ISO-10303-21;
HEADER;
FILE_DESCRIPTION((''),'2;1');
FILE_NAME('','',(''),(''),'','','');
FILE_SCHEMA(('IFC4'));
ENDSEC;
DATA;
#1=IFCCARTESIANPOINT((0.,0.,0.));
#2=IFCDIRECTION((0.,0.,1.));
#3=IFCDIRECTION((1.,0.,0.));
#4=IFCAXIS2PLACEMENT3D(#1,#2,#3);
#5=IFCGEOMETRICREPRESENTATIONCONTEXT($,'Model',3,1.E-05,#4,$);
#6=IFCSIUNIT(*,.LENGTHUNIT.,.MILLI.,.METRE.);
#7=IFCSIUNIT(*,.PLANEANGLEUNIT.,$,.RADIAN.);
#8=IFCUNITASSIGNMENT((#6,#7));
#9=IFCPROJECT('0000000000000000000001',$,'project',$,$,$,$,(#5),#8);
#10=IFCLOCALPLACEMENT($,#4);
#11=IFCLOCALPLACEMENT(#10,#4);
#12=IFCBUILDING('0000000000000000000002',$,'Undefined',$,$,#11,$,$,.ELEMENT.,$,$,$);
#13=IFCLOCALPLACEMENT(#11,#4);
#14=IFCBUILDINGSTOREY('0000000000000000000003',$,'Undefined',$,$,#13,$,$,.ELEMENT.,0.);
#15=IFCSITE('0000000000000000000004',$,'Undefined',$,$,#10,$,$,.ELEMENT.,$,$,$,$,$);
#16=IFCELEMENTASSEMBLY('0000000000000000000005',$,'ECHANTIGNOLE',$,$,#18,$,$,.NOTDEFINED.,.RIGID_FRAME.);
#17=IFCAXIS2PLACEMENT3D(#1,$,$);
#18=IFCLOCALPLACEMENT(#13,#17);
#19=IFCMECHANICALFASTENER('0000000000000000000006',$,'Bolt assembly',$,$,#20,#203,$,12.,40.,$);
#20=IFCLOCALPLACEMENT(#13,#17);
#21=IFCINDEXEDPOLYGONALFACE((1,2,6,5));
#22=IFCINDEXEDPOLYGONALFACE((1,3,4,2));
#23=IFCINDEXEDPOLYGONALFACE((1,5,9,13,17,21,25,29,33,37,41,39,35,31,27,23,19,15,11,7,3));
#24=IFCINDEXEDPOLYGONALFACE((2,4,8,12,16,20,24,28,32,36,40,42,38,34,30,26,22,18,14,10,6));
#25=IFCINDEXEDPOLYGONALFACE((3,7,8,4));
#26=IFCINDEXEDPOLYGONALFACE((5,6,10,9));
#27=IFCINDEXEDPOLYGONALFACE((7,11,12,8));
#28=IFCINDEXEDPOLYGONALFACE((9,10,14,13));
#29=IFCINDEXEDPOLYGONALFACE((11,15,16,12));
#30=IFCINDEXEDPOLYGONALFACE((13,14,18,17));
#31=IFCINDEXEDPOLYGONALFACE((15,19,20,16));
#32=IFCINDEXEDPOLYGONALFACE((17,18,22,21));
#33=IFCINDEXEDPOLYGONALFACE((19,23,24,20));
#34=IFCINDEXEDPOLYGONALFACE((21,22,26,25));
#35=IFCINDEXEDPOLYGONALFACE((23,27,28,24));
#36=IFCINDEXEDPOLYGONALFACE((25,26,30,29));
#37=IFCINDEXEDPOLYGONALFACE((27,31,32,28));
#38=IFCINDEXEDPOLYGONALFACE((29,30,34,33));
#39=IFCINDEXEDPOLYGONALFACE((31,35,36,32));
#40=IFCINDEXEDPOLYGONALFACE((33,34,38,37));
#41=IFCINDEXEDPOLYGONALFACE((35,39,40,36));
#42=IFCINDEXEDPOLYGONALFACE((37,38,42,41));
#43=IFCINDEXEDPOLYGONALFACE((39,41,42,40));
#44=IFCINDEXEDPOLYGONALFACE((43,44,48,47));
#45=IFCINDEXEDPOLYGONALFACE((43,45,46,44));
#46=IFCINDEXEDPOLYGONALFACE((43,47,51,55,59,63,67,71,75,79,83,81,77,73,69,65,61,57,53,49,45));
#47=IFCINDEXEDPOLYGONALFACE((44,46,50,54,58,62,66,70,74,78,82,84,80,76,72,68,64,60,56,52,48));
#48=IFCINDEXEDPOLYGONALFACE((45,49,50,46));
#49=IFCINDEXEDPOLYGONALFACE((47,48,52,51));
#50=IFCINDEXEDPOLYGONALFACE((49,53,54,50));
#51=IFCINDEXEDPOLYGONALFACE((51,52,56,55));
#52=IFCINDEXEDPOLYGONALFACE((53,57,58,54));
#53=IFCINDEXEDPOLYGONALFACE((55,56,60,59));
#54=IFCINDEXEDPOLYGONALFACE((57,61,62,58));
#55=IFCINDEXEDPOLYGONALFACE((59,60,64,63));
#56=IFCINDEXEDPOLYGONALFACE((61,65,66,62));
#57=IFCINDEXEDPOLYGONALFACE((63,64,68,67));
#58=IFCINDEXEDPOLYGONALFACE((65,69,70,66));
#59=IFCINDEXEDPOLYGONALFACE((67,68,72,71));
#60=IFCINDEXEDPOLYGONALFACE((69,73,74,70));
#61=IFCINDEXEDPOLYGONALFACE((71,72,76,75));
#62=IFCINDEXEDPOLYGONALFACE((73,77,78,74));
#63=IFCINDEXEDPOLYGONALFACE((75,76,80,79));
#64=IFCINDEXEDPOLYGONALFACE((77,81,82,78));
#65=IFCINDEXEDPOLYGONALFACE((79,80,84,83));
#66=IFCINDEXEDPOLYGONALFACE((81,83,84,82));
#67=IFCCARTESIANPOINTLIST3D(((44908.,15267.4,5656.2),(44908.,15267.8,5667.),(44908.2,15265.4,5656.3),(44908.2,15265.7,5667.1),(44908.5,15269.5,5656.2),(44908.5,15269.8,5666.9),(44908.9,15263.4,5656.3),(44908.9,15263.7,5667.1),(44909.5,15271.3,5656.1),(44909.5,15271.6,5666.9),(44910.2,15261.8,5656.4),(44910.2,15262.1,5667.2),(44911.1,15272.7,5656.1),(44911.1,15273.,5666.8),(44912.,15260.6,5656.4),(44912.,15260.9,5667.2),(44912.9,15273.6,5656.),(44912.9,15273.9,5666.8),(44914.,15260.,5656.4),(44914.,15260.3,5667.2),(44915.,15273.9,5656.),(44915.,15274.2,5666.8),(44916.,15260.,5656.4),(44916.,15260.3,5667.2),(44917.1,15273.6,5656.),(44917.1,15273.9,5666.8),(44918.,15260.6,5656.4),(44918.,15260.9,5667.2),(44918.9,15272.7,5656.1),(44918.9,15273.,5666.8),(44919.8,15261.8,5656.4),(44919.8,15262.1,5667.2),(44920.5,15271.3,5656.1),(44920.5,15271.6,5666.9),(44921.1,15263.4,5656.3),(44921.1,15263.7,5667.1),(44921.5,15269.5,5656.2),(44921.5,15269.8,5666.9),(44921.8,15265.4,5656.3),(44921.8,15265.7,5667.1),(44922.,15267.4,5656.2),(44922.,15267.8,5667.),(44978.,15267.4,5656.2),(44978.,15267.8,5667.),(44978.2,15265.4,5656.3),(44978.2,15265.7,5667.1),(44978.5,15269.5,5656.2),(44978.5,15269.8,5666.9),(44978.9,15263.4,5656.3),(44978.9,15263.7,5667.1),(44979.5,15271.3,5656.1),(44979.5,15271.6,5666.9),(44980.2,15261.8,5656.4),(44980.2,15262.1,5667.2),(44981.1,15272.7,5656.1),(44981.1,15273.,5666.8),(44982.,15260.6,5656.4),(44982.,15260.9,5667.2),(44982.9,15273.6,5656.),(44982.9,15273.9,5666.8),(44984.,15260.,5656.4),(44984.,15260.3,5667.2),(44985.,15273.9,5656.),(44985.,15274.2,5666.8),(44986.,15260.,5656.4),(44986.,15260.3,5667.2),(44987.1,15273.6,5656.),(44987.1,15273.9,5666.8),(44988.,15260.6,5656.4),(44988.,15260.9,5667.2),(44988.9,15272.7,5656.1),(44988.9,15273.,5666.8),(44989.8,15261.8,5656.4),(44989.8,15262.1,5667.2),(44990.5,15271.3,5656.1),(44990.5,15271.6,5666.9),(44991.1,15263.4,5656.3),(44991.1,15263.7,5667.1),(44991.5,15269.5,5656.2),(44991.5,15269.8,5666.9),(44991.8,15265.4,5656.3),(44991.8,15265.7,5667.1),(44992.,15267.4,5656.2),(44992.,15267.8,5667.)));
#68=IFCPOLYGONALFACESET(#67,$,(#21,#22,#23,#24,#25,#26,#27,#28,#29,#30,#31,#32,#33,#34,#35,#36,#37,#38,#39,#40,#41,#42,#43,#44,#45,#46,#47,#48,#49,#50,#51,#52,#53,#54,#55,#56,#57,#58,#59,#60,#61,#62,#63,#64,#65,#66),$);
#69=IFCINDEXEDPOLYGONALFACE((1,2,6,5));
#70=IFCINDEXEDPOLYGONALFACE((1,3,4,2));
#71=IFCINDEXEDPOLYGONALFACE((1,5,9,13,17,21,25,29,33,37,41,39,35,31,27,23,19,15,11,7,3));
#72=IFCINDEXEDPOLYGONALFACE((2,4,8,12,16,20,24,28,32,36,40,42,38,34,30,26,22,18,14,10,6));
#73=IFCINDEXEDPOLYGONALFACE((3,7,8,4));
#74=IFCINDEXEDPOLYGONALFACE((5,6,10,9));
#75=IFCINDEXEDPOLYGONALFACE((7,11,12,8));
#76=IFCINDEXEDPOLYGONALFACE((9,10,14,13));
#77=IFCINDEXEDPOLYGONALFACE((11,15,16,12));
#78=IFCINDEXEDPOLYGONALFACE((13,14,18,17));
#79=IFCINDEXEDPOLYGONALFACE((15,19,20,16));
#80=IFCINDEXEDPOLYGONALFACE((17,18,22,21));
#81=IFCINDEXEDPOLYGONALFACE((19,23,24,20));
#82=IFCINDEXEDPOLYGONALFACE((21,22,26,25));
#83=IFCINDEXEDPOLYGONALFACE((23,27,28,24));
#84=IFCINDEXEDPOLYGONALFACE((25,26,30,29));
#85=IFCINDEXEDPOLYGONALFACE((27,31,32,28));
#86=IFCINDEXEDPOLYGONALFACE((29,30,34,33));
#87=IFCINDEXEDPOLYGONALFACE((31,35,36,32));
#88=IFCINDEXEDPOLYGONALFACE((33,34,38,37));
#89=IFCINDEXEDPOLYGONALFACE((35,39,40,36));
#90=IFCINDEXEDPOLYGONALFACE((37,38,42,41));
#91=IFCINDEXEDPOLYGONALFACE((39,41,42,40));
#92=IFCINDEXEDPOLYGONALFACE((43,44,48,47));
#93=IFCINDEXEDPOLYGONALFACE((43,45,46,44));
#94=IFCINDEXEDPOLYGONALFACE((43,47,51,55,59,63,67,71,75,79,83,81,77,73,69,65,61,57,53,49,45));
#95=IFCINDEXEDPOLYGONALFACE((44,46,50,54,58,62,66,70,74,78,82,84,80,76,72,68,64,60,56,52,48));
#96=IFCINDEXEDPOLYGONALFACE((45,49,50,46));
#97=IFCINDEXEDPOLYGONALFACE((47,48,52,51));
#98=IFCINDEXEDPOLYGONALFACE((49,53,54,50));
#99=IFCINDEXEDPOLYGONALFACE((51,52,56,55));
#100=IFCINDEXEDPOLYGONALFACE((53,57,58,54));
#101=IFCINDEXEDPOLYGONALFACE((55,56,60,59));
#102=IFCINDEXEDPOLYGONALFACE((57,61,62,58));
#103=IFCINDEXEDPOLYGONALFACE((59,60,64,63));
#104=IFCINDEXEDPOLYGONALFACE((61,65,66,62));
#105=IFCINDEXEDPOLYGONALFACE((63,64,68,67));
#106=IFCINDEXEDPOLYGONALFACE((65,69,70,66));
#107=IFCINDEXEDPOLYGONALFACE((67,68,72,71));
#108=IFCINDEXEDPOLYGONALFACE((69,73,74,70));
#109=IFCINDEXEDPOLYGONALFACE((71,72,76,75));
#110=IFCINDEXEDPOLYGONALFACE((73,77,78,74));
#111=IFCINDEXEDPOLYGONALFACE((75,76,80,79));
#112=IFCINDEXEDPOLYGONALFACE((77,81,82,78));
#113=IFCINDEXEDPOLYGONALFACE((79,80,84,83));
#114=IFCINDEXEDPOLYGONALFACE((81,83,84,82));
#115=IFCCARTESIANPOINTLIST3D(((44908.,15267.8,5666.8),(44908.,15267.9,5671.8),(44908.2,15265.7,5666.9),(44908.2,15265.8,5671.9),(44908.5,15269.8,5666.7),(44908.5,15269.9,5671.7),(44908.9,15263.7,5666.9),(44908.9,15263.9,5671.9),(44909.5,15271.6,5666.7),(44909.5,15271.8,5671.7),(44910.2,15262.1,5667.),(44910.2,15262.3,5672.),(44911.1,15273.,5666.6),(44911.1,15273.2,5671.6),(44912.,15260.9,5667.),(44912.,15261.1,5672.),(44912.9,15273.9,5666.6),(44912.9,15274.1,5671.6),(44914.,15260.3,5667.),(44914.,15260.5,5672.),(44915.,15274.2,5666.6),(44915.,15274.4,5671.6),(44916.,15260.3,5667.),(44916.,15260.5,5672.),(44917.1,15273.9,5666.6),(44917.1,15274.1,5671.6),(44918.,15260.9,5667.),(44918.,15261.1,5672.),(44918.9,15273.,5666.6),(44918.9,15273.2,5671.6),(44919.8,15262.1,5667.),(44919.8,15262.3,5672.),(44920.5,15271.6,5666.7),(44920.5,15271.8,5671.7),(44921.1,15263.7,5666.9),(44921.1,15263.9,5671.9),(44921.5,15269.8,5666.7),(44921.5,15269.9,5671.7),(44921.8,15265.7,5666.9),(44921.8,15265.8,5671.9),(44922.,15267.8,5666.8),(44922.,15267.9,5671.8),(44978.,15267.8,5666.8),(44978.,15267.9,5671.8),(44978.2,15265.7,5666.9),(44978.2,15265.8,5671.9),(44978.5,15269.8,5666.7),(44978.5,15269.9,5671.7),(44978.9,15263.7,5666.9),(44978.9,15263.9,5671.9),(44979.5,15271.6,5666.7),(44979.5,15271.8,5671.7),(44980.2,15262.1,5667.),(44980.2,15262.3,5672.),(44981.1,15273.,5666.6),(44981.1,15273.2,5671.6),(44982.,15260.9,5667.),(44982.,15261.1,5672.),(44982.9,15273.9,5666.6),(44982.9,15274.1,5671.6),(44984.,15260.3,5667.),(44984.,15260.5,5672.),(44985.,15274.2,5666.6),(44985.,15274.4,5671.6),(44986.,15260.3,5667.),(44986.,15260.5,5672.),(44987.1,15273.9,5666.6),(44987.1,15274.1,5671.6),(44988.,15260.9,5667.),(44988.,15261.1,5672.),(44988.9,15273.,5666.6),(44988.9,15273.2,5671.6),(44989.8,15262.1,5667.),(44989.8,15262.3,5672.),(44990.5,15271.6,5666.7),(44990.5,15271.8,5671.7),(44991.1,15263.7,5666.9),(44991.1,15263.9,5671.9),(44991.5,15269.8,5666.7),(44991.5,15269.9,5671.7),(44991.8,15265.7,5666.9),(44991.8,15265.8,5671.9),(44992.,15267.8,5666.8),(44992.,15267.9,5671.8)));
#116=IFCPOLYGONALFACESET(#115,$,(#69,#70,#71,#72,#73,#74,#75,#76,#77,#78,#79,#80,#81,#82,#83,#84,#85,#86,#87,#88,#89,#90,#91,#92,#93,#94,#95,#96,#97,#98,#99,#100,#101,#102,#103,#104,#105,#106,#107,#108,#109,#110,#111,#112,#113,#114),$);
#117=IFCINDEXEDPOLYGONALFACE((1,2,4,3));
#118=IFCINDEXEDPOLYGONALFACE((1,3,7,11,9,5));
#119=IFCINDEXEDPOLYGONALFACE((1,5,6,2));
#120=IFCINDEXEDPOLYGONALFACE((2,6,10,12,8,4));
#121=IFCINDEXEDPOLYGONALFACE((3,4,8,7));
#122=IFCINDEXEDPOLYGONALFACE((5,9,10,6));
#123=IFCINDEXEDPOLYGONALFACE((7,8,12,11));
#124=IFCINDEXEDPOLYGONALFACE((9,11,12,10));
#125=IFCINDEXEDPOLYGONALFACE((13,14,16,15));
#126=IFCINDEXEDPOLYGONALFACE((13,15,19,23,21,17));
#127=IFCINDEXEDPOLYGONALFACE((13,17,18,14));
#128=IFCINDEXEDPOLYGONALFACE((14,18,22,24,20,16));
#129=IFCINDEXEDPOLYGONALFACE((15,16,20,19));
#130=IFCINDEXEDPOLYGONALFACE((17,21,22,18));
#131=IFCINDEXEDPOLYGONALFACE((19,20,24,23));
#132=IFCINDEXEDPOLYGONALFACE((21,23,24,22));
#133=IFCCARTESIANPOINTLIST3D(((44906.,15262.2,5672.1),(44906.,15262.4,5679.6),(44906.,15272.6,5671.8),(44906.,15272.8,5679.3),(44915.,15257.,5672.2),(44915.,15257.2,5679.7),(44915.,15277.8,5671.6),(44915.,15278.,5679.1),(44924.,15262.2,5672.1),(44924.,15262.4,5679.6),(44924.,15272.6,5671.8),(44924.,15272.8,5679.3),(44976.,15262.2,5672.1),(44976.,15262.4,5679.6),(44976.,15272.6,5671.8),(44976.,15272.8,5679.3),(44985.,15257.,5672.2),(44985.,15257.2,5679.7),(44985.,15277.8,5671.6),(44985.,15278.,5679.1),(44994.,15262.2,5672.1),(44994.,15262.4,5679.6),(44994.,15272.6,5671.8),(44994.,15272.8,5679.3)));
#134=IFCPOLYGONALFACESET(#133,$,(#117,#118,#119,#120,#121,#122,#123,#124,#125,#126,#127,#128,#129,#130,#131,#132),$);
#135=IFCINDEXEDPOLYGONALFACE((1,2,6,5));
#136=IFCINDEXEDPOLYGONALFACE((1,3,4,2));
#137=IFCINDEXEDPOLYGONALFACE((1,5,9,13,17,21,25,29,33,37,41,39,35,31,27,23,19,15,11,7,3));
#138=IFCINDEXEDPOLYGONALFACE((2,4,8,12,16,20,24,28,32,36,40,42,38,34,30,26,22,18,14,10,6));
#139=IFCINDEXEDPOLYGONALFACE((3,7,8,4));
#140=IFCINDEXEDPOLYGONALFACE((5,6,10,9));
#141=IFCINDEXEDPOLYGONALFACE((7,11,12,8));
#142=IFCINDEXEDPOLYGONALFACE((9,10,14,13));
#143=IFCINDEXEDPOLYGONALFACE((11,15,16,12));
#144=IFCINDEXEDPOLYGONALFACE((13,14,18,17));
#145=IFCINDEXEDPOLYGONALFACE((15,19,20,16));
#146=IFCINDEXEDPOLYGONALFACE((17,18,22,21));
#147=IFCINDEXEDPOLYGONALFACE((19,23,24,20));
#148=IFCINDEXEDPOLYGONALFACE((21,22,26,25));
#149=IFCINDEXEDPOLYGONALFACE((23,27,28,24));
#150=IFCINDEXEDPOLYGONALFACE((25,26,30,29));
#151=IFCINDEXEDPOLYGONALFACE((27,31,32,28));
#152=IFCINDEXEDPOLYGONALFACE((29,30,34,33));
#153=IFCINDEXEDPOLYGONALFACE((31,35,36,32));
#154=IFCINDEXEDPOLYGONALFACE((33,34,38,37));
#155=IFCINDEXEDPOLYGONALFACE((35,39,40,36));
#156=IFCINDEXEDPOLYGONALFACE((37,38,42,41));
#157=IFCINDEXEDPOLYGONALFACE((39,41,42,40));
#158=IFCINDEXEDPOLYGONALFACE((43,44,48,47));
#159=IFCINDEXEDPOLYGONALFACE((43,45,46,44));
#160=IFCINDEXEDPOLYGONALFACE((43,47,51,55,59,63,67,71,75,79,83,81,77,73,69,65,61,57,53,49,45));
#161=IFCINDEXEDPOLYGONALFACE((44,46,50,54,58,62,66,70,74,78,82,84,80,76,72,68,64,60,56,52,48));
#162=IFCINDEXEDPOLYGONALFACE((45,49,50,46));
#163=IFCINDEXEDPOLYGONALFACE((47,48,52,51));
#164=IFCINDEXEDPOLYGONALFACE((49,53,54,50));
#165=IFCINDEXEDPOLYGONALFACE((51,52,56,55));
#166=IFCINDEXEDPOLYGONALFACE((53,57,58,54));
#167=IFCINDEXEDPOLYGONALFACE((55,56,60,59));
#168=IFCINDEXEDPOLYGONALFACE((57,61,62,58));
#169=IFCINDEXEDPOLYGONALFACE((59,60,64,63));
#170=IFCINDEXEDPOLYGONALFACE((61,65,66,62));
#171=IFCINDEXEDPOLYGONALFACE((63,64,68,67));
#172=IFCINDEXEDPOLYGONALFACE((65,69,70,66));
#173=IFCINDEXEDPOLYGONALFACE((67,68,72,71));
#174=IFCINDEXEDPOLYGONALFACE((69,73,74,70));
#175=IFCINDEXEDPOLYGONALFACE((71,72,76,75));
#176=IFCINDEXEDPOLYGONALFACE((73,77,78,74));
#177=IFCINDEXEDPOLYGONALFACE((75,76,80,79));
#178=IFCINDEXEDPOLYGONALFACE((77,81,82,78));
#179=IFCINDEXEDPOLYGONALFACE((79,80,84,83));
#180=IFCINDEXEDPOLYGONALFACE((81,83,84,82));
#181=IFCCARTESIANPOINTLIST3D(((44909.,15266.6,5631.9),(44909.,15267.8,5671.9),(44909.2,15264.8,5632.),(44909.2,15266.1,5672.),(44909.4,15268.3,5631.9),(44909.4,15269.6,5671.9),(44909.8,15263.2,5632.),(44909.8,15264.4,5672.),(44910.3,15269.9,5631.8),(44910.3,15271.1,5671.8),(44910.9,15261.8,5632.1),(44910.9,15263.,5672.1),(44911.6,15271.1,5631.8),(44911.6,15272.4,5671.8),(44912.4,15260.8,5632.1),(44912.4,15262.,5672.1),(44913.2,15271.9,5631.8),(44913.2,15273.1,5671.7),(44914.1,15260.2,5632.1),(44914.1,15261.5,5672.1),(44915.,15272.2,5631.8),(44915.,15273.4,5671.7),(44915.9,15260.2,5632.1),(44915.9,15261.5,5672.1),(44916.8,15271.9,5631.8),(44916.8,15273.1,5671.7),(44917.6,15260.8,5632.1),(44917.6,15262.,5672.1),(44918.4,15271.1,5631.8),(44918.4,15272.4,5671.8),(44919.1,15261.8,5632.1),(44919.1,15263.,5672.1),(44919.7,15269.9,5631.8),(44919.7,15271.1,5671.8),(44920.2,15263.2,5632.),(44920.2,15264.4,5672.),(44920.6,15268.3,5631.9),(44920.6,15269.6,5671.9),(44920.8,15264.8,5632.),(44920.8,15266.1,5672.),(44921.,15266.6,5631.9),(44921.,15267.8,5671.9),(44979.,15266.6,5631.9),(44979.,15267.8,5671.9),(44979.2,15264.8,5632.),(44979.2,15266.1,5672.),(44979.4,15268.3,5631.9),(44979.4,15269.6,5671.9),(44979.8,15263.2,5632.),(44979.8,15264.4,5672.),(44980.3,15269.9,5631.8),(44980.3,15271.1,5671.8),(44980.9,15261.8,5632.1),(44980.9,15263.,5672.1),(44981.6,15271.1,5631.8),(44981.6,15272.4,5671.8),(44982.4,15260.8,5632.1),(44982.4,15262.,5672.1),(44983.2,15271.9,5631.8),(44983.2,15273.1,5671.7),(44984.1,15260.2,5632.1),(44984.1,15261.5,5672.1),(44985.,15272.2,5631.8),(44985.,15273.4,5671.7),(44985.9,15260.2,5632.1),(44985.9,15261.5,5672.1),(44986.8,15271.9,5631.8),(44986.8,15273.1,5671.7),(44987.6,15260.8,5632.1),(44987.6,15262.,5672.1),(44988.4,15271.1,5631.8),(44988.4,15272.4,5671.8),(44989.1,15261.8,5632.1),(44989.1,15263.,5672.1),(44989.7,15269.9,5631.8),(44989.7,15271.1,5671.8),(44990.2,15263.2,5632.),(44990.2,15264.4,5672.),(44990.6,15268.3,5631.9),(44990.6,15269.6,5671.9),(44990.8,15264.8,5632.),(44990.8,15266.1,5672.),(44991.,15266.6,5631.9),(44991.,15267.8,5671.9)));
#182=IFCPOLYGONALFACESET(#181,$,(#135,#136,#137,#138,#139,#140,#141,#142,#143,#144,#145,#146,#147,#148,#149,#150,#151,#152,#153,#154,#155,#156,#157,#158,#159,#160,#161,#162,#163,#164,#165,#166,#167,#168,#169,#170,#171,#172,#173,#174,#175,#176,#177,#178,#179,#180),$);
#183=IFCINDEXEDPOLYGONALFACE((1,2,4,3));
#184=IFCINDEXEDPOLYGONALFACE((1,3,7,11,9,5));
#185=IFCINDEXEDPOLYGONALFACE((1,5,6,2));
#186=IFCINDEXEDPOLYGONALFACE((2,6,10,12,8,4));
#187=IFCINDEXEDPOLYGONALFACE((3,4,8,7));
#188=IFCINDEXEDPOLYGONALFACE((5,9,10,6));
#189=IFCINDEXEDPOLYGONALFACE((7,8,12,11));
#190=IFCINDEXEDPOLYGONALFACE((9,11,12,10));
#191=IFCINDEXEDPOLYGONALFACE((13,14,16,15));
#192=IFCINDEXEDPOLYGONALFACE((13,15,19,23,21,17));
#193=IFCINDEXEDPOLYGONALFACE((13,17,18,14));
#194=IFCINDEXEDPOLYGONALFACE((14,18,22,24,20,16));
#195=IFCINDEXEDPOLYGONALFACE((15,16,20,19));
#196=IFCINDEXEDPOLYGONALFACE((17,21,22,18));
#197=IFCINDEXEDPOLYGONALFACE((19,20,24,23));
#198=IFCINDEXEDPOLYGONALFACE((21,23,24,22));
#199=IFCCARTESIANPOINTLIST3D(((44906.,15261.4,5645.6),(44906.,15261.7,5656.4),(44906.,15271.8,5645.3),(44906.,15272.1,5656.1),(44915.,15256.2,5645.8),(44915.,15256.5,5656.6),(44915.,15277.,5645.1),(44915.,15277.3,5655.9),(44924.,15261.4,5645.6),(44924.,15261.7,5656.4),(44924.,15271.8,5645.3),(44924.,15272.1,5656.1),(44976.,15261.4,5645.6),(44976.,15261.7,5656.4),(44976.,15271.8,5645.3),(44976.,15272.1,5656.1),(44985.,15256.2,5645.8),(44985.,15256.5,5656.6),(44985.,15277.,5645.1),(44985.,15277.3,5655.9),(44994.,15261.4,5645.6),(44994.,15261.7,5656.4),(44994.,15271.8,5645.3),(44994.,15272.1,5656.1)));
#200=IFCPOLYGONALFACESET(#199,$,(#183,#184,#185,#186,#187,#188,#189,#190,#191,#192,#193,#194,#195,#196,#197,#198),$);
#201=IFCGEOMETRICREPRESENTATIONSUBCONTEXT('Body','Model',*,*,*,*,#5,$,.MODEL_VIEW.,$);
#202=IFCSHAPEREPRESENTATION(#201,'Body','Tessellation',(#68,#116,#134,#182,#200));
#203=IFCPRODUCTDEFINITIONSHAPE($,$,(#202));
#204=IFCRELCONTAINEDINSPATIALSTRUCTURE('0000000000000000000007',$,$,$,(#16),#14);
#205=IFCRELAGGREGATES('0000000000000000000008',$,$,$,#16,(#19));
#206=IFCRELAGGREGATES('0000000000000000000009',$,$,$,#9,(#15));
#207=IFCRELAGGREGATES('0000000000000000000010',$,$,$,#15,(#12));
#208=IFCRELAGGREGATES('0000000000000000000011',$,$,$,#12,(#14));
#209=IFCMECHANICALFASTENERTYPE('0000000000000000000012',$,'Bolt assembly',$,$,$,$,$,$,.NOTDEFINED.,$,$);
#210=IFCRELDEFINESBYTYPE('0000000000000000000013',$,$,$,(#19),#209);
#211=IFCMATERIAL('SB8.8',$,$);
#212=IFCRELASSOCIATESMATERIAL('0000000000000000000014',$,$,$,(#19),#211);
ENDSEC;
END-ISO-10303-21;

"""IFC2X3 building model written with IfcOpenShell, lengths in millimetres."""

from ifc_helpers import new_model, si_unit, frame, origin_with_axes, origin_2d_with_axis, place, context, subcontext, project, spatial, polyline, circle, outline, extrude, source, transform, mapped, material, type_object, element, aggregate, save


model = new_model("IFC2X3")

# Units and contexts
model_context = context("Model", 3, precision=1e-05, world=origin_with_axes())
body_context = subcontext(model_context, "Body", "Model", "MODEL_VIEW")
ifc_project = project(units=[si_unit("LENGTHUNIT", "METRE", prefix="MILLI"), si_unit("PLANEANGLEUNIT", "RADIAN")], contexts=[model_context])

# Site, building, storey
site_placement = place(None, origin_with_axes())
site = spatial("IfcSite", under=ifc_project, at=site_placement, Name="Undefined", CompositionType="ELEMENT")
building_placement = place(site_placement, origin_with_axes())
building = spatial("IfcBuilding", under=site, at=building_placement, Name="Undefined", CompositionType="ELEMENT")
storey_placement = place(building_placement, origin_with_axes())
storey = spatial("IfcBuildingStorey", under=building, at=storey_placement, Name="Undefined", CompositionType="ELEMENT", Elevation=0.0)

# Shared definitions
ifc_material_1 = material(Name="SB8.8")
mechanical_fastener_type = type_object("IfcMechanicalFastenerType", Name="Bolt assembly")

# Element assembly, mechanical fastener
assembly_1_placement = place(storey_placement, origin_with_axes())
assembly_1 = element("IfcElementAssembly", 1, at=assembly_1_placement, inside=storey, Name="ECHANTIGNOLE", AssemblyPlace="NOTDEFINED", PredefinedType="RIGID_FRAME")
shared_shape_1 = source(origin_with_axes(), body_context, "Body", "SweptSolid", [
    extrude(circle(Radius=7.0, at=origin_2d_with_axis()), frame((0.0, -0.1, 0.0), z_axis=(0.0, 1.0, 0.0), x_axis=(1.0, 0.0, 0.0)), (0.0, 0.0, 1.0), 10.8),
    extrude(circle(Radius=7.0, at=origin_2d_with_axis()), frame((0.0, -4.9, 0.0), z_axis=(0.0, 1.0, 0.0), x_axis=(1.0, 0.0, 0.0)), (0.0, 0.0, 1.0), 5.0),
    extrude(outline(polyline([(10.4, 0.0), (5.2, 9.0), (-5.2, 9.0), (-10.4, 0.0), (-5.2, -9.0), (5.2, -9.0), (10.4, 0.0)])), frame((0.0, -12.5, 0.0), z_axis=(0.0, 1.0, 0.0), x_axis=(1.0, 0.0, 0.0)), (0.0, 0.0, 1.0), 7.5),
    extrude(circle(Radius=6.0, at=origin_2d_with_axis()), frame((0.0, -5.0, 0.0), z_axis=(0.0, 1.0, 0.0), x_axis=(1.0, 0.0, 0.0)), (0.0, 0.0, 1.0), 40.0),
    extrude(outline(polyline([(10.4, 0.0), (5.2, 9.0), (-5.2, 9.0), (-10.4, 0.0), (-5.2, -9.0), (5.2, -9.0), (10.4, 0.0)])), frame((0.0, 10.7, 0.0), z_axis=(0.0, 1.0, 0.0), x_axis=(1.0, 0.0, 0.0)), (0.0, 0.0, 1.0), 10.8),
])
mechanical_fastener_1_placement = place(assembly_1_placement, frame((44950.0, 15267.2, 5666.9), z_axis=(-1.0, 0.0, 0.0), x_axis=(0.0, 0.99952, -0.030986)))
mechanical_fastener_1 = element("IfcMechanicalFastener", 2, at=mechanical_fastener_1_placement, type_object=mechanical_fastener_type, material=ifc_material_1, Name="Bolt assembly", NominalDiameter=12.0, NominalLength=40.0, context=body_context, shape_type="MappedRepresentation", body=[
    mapped(shared_shape_1, transform((0.0, 0.0, 35.0))),
    mapped(shared_shape_1, transform((0.0, 0.0, -35.0))),
])
aggregate(assembly_1, [mechanical_fastener_1])

save(model, "model.ifc")
